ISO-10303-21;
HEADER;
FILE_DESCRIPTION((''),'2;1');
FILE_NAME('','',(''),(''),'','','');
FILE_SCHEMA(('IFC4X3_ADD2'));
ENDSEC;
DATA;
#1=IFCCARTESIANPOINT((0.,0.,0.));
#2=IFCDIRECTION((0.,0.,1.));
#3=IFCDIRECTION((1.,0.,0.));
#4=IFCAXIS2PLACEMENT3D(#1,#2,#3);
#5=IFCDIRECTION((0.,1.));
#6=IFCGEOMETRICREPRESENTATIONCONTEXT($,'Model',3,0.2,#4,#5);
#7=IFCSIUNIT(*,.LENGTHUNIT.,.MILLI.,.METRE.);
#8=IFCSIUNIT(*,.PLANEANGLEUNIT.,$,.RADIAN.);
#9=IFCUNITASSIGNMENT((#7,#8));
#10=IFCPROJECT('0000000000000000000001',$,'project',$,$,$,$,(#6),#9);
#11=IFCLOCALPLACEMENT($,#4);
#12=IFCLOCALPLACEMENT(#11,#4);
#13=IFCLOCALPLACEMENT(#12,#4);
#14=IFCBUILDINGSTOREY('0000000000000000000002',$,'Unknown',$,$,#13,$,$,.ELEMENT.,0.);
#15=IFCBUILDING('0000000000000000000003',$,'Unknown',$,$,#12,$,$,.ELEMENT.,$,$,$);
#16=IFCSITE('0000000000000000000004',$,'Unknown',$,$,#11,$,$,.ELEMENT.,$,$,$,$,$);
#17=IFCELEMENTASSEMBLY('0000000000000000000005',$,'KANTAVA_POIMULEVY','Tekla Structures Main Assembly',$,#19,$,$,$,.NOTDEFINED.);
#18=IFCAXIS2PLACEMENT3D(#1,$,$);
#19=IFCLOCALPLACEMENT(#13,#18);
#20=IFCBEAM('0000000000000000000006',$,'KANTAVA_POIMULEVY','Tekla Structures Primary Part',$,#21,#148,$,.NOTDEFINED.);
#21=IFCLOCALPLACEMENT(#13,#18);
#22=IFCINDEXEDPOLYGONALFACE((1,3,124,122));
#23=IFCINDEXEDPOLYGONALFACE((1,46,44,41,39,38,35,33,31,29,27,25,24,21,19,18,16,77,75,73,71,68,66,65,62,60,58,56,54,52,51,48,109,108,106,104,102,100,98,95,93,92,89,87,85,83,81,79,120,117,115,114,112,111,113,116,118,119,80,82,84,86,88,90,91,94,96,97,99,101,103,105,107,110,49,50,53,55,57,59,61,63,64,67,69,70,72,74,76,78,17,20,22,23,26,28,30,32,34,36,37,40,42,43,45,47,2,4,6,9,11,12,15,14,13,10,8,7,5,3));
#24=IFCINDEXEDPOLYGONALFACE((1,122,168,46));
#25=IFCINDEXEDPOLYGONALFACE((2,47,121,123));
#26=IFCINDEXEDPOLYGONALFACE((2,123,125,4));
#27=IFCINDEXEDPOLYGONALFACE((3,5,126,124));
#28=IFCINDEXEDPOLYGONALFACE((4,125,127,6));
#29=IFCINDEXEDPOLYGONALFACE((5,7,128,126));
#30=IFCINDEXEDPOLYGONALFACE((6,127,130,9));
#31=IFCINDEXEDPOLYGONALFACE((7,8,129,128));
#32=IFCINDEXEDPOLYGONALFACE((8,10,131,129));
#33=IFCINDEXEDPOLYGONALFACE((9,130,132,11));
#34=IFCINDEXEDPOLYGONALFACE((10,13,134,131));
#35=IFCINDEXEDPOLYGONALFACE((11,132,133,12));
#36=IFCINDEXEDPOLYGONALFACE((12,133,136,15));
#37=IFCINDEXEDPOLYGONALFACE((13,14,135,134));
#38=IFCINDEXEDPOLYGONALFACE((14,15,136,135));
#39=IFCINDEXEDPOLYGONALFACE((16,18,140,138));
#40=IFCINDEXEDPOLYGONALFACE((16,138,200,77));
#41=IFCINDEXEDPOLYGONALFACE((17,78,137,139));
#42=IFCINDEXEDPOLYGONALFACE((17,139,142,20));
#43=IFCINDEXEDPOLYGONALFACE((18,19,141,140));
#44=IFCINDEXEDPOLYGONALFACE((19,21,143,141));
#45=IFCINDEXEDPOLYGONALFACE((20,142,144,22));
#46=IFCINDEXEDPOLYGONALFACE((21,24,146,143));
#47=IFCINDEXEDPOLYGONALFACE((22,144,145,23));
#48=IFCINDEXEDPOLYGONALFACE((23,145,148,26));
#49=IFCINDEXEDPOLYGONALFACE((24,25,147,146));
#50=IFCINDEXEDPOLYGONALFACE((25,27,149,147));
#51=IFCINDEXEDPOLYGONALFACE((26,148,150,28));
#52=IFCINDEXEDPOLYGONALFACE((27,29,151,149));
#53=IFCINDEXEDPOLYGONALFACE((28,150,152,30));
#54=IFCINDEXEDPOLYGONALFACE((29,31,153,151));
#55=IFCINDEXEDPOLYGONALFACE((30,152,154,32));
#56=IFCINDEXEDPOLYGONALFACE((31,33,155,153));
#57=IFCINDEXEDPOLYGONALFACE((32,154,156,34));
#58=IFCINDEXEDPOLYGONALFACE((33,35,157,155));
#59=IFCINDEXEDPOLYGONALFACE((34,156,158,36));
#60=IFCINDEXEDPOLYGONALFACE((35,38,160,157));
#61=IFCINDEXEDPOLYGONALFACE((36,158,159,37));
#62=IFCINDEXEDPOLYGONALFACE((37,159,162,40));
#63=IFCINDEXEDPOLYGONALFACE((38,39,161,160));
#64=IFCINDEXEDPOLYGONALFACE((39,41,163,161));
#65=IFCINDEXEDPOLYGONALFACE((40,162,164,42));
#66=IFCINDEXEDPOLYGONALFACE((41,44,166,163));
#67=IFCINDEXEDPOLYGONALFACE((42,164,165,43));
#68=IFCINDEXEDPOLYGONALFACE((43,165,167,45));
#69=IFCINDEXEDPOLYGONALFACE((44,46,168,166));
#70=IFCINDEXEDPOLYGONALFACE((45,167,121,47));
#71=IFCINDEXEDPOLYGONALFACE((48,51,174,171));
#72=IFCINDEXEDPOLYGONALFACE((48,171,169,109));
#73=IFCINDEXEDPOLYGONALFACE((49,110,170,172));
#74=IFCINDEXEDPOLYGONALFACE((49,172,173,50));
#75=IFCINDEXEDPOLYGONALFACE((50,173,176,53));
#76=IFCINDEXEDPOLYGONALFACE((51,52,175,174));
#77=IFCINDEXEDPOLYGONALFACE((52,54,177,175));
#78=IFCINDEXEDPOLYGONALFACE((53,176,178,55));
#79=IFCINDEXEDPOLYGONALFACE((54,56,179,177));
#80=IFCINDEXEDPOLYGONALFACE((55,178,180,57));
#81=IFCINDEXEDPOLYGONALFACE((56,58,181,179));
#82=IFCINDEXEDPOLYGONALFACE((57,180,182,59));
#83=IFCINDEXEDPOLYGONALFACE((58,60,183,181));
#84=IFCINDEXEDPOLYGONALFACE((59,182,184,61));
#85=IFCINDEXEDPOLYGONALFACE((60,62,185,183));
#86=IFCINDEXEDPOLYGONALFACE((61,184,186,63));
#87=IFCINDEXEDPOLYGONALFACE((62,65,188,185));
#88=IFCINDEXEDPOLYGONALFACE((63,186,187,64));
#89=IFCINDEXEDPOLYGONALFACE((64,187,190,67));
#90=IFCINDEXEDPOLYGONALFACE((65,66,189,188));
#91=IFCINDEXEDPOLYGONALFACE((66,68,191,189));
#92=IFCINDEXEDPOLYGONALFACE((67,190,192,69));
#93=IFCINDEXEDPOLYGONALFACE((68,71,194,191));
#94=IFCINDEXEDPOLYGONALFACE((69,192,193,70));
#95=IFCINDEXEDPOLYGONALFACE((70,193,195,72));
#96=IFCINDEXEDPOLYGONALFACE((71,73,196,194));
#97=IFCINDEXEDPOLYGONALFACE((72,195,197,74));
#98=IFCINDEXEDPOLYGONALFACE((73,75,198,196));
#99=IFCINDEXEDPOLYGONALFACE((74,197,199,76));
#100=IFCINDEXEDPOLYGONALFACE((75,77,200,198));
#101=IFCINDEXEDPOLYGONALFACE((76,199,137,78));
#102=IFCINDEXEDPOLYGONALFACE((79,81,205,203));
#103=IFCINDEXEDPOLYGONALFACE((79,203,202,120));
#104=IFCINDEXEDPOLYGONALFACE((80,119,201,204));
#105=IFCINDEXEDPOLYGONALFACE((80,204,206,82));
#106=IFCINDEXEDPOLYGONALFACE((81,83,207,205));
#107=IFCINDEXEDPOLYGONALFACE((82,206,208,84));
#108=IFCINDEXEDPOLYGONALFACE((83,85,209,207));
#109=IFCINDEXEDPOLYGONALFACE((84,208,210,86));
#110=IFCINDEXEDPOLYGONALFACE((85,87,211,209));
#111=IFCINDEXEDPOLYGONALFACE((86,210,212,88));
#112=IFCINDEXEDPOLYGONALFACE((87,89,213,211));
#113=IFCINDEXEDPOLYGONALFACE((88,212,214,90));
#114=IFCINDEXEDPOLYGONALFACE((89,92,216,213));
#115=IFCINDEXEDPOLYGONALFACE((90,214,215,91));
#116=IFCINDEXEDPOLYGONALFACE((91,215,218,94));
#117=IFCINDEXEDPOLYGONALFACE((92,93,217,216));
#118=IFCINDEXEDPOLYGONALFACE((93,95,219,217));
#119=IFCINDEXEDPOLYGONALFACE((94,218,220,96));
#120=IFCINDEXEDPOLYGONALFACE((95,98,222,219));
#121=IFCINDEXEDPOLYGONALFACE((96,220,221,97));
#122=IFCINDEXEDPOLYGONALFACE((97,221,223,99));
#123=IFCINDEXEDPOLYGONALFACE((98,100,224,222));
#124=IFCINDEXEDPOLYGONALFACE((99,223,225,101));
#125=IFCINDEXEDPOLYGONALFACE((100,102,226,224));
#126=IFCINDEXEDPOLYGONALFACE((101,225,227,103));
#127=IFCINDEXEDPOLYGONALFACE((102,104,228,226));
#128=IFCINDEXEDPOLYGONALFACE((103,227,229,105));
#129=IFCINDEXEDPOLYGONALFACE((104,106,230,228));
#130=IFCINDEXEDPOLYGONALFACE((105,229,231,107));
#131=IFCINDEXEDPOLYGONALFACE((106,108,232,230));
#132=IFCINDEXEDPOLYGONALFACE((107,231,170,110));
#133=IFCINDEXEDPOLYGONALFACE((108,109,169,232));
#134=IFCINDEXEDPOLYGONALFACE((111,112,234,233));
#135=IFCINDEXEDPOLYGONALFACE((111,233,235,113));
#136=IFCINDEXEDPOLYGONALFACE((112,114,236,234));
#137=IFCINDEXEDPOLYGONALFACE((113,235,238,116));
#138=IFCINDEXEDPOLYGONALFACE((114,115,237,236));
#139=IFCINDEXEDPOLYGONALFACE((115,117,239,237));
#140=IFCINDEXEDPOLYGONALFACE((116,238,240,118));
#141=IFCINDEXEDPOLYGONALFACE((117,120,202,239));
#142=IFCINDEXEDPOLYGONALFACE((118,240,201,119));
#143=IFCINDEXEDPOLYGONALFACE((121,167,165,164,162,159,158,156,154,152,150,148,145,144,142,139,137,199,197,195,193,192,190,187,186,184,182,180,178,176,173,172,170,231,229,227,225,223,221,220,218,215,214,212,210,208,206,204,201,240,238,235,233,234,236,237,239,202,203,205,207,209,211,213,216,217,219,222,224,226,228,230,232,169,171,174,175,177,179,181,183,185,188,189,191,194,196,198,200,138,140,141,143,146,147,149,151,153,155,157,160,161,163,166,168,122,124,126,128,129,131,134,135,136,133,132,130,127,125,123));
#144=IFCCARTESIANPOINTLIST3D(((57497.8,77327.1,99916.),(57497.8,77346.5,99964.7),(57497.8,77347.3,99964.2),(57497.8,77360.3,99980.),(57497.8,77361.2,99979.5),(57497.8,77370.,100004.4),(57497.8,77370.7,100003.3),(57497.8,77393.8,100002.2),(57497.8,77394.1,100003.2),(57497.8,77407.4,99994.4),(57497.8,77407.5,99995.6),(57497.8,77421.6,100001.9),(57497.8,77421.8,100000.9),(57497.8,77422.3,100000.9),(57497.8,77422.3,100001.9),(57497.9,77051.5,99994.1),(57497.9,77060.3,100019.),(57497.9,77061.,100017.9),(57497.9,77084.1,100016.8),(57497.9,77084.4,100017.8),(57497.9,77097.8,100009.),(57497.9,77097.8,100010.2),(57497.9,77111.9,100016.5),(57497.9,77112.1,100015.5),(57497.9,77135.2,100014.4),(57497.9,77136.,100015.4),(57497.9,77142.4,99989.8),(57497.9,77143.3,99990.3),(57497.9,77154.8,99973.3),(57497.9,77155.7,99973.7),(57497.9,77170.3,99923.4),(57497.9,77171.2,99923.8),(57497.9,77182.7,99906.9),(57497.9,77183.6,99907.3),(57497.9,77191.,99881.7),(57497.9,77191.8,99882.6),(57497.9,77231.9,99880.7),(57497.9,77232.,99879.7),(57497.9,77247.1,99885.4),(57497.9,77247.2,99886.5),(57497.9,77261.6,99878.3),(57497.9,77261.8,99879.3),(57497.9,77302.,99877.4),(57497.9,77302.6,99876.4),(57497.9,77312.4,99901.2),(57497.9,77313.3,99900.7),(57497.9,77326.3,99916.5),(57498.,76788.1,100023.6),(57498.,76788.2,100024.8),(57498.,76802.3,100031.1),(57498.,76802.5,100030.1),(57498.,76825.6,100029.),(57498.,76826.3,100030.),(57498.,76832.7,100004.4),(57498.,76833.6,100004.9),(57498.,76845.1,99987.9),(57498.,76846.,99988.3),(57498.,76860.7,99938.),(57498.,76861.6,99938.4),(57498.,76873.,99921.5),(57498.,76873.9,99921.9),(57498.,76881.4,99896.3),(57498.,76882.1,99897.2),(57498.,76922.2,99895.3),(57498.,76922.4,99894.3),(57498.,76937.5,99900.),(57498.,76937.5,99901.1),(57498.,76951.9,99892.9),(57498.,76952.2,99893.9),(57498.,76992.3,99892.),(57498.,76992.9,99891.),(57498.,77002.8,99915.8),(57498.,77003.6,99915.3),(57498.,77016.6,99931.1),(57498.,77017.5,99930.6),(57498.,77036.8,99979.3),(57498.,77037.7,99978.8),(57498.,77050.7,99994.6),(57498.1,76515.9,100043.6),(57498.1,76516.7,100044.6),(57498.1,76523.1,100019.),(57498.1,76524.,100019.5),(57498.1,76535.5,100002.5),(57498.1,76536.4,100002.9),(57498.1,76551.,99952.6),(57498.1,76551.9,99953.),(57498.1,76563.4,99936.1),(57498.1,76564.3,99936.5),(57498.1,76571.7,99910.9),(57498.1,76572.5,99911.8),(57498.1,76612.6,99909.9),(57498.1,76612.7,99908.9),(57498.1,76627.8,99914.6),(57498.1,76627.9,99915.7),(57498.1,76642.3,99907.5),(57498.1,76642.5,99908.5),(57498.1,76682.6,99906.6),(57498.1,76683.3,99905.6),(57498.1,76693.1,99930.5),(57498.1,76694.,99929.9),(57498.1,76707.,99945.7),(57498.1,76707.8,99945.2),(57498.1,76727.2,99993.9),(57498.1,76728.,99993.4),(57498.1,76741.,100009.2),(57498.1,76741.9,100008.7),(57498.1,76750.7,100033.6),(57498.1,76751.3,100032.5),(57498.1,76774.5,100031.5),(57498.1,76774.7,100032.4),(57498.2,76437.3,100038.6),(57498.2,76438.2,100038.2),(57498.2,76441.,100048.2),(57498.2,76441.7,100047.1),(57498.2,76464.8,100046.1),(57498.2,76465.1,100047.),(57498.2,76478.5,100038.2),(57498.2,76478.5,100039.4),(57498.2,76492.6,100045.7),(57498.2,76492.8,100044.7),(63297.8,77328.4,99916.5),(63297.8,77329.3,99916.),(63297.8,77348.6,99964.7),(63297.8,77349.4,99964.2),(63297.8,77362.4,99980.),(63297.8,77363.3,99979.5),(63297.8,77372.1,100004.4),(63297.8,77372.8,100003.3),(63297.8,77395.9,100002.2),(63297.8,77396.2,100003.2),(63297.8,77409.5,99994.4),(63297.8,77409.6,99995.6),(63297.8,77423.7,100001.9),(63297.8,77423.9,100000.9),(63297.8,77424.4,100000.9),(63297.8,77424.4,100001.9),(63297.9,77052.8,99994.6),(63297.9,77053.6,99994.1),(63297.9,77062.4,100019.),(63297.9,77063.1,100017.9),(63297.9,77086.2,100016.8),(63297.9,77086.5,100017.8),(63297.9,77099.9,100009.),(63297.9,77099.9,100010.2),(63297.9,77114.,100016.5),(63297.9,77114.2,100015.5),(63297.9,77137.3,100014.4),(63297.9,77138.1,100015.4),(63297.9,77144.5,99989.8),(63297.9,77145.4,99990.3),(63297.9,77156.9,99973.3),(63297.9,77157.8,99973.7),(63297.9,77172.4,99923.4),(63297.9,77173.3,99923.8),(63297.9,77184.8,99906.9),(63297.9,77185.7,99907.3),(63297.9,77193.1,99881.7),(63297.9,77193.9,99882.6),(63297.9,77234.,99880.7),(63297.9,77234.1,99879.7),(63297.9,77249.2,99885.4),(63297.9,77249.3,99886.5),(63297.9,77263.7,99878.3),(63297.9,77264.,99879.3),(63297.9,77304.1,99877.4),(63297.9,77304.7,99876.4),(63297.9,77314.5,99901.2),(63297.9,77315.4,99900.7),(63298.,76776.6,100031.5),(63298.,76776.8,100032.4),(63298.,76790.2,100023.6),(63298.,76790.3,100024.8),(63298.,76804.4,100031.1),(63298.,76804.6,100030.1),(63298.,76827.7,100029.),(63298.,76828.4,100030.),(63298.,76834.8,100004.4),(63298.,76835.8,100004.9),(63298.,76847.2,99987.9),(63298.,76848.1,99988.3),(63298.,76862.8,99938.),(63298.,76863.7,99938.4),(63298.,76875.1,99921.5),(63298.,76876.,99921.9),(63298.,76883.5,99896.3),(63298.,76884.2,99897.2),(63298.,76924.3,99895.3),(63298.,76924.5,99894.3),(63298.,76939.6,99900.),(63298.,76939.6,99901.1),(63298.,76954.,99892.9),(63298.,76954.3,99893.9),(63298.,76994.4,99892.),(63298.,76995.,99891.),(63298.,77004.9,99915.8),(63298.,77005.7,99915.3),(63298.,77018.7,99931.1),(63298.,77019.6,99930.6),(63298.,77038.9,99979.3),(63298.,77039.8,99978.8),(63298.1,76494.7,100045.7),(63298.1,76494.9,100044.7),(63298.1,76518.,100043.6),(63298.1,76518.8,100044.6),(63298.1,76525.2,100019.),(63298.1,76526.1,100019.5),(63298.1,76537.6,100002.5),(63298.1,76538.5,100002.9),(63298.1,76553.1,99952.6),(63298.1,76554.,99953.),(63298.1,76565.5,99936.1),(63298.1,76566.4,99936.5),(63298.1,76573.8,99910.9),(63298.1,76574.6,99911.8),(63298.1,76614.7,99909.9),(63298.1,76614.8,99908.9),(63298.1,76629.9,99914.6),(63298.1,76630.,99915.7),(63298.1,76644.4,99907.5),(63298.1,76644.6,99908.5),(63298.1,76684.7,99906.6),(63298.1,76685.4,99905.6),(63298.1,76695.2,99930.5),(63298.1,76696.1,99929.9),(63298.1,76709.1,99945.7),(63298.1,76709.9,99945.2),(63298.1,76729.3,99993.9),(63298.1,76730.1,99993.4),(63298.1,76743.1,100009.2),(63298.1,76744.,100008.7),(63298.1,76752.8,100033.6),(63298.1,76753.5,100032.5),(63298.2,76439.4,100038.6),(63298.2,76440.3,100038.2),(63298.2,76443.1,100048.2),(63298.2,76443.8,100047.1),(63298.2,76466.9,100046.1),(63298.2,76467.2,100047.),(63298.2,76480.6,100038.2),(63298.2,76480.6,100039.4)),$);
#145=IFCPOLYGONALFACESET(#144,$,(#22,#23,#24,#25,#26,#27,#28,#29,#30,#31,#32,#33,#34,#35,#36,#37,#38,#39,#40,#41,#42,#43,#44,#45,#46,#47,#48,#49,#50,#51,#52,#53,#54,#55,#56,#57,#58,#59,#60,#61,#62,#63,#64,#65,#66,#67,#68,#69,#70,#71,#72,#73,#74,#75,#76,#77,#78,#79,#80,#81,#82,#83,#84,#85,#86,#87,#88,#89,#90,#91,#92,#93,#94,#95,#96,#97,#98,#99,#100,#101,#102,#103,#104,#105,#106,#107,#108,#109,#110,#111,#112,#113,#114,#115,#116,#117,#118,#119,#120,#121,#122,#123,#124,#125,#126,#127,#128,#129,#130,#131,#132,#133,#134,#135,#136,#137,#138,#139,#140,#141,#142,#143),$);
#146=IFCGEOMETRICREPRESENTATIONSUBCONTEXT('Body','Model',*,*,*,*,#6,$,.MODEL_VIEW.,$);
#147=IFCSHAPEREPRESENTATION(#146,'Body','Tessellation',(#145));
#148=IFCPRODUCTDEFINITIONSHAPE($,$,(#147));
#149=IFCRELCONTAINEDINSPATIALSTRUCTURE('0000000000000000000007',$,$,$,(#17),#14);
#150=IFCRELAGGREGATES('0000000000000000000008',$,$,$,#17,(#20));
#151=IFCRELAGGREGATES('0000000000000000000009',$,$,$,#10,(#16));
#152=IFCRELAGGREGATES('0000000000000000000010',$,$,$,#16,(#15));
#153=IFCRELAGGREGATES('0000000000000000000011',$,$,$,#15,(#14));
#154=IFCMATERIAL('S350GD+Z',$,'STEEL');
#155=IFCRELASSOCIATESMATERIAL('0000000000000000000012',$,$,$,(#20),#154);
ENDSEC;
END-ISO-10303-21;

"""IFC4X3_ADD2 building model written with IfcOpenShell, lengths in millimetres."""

from ifc_helpers import new_model, si_unit, direction, frame, origin_with_axes, place, context, subcontext, project, spatial, line, indexed_curve, outline, extrude, material, element, aggregate, save


model = new_model("IFC4X3_ADD2")

# Units and contexts
model_context = context("Model", 3, precision=0.2, world=origin_with_axes(), true_north=direction((0.0, 1.0)))
body_context = subcontext(model_context, "Body", "Model", "MODEL_VIEW")
ifc_project = project(units=[si_unit("LENGTHUNIT", "METRE", prefix="MILLI"), si_unit("PLANEANGLEUNIT", "RADIAN")], contexts=[model_context])

# Site, building, storey
site_placement = place(None, origin_with_axes())
site = spatial("IfcSite", under=ifc_project, at=site_placement, Name="Unknown", CompositionType="ELEMENT")
building_placement = place(site_placement, origin_with_axes())
building = spatial("IfcBuilding", under=site, at=building_placement, Name="Unknown", CompositionType="ELEMENT")
storey_placement = place(building_placement, origin_with_axes())
storey = spatial("IfcBuildingStorey", under=building, at=storey_placement, Name="Unknown", CompositionType="ELEMENT", Elevation=0.0)

# Element assembly, beam
ifc_material_1 = material(Name="S350GD+Z", Category="STEEL")
assembly_1_placement = place(storey_placement, frame((63298.0, 76942.4, 99959.1), z_axis=(-0.000363, 0.99889, -0.047106), x_axis=(-1.0, -0.000363, 0.0)))
assembly_1 = element("IfcElementAssembly", 1, at=assembly_1_placement, inside=storey, Name="KANTAVA_POIMULEVY", Description="Tekla Structures Main Assembly", PredefinedType="NOTDEFINED")
beam_1_placement = place(assembly_1_placement, origin_with_axes())
beam_1 = element("IfcBeam", 2, at=beam_1_placement, material=ifc_material_1, Name="KANTAVA_POIMULEVY", Description="Tekla Structures Primary Part", PredefinedType="NOTDEFINED", context=body_context, shape_type="SolidModel", body=[
    extrude(outline(indexed_curve([(479.5, 65.5), (478.8, 65.5), (465.0, 58.5), (451.2, 65.5), (427.1, 65.5), (418.6, 40.7), (405.5, 24.8), (387.6, -24.3), (374.5, -40.2), (365.1, -64.5), (325.0, -64.5), (310.0, -58.1), (295.0, -64.5), (254.8, -64.5), (245.5, -40.2), (232.4, -24.3), (214.5, 24.8), (201.4, 40.7), (192.9, 65.5), (168.8, 65.5), (155.0, 58.5), (141.2, 65.5), (117.1, 65.5), (108.6, 40.7), (95.5, 24.8), (77.6, -24.3), (64.5, -40.2), (55.1, -64.5), (15.0, -64.5), (0.0, -58.1), (-15.0, -64.5), (-55.2, -64.5), (-64.5, -40.2), (-77.6, -24.3), (-95.5, 24.8), (-108.6, 40.7), (-117.2, 65.5), (-141.2, 65.5), (-155.0, 58.5), (-168.8, 65.5), (-192.9, 65.5), (-201.4, 40.7), (-214.5, 24.8), (-232.4, -24.3), (-245.5, -40.2), (-254.9, -64.5), (-295.0, -64.5), (-310.0, -58.1), (-325.0, -64.5), (-365.2, -64.5), (-374.5, -40.2), (-387.6, -24.3), (-405.5, 24.8), (-418.6, 40.7), (-427.1, 65.5), (-451.2, 65.5), (-465.0, 58.5), (-478.8, 65.5), (-502.9, 65.5), (-506.2, 55.7), (-505.2, 55.4), (-502.1, 64.5), (-479.0, 64.5), (-465.0, 57.3), (-451.0, 64.5), (-427.9, 64.5), (-419.5, 40.2), (-406.4, 24.3), (-388.5, -24.8), (-375.4, -40.7), (-365.9, -65.5), (-324.8, -65.5), (-310.0, -59.1), (-295.2, -65.5), (-254.2, -65.5), (-244.6, -40.7), (-231.5, -24.8), (-213.6, 24.3), (-200.5, 40.2), (-192.1, 64.5), (-169.0, 64.5), (-155.0, 57.3), (-141.0, 64.5), (-117.9, 64.5), (-109.5, 40.2), (-96.4, 24.3), (-78.5, -24.8), (-65.4, -40.7), (-55.9, -65.5), (-14.8, -65.5), (0.0, -59.1), (14.8, -65.5), (55.8, -65.5), (65.4, -40.7), (78.5, -24.8), (96.4, 24.3), (109.5, 40.2), (117.8, 64.5), (141.0, 64.5), (155.0, 57.3), (169.0, 64.5), (192.1, 64.5), (200.5, 40.2), (213.6, 24.3), (231.5, -24.8), (244.6, -40.7), (254.1, -65.5), (295.2, -65.5), (310.0, -59.1), (324.8, -65.5), (365.8, -65.5), (375.4, -40.7), (388.5, -24.8), (406.4, 24.3), (419.5, 40.2), (427.9, 64.5), (451.0, 64.5), (465.0, 57.3), (479.0, 64.5), (479.5, 64.5)], segments=[line(1, 2, 3, 4, 5, 6, 7, 8, 9, 10, 11, 12, 13, 14, 15, 16, 17, 18, 19, 20, 21, 22, 23, 24, 25, 26, 27, 28, 29, 30, 31, 32, 33, 34, 35, 36, 37, 38, 39, 40, 41, 42, 43, 44, 45, 46, 47, 48, 49, 50, 51, 52, 53, 54, 55, 56, 57, 58, 59, 60, 61, 62, 63, 64, 65, 66, 67, 68, 69, 70, 71, 72, 73, 74, 75, 76, 77, 78, 79, 80, 81, 82, 83, 84, 85, 86, 87, 88, 89, 90, 91, 92, 93, 94, 95, 96, 97, 98, 99, 100, 101, 102, 103, 104, 105, 106, 107, 108, 109, 110, 111, 112, 113, 114, 115, 116, 117, 118, 119, 120, 1)])), frame((0.0, 0.0, 0.0), z_axis=(-1.0, 0.0, 0.0), x_axis=(0.0, 0.0, 1.0)), (0.0, 0.0, -1.0), 5800.0),
])
aggregate(assembly_1, [beam_1])

save(model, "model.ifc")
